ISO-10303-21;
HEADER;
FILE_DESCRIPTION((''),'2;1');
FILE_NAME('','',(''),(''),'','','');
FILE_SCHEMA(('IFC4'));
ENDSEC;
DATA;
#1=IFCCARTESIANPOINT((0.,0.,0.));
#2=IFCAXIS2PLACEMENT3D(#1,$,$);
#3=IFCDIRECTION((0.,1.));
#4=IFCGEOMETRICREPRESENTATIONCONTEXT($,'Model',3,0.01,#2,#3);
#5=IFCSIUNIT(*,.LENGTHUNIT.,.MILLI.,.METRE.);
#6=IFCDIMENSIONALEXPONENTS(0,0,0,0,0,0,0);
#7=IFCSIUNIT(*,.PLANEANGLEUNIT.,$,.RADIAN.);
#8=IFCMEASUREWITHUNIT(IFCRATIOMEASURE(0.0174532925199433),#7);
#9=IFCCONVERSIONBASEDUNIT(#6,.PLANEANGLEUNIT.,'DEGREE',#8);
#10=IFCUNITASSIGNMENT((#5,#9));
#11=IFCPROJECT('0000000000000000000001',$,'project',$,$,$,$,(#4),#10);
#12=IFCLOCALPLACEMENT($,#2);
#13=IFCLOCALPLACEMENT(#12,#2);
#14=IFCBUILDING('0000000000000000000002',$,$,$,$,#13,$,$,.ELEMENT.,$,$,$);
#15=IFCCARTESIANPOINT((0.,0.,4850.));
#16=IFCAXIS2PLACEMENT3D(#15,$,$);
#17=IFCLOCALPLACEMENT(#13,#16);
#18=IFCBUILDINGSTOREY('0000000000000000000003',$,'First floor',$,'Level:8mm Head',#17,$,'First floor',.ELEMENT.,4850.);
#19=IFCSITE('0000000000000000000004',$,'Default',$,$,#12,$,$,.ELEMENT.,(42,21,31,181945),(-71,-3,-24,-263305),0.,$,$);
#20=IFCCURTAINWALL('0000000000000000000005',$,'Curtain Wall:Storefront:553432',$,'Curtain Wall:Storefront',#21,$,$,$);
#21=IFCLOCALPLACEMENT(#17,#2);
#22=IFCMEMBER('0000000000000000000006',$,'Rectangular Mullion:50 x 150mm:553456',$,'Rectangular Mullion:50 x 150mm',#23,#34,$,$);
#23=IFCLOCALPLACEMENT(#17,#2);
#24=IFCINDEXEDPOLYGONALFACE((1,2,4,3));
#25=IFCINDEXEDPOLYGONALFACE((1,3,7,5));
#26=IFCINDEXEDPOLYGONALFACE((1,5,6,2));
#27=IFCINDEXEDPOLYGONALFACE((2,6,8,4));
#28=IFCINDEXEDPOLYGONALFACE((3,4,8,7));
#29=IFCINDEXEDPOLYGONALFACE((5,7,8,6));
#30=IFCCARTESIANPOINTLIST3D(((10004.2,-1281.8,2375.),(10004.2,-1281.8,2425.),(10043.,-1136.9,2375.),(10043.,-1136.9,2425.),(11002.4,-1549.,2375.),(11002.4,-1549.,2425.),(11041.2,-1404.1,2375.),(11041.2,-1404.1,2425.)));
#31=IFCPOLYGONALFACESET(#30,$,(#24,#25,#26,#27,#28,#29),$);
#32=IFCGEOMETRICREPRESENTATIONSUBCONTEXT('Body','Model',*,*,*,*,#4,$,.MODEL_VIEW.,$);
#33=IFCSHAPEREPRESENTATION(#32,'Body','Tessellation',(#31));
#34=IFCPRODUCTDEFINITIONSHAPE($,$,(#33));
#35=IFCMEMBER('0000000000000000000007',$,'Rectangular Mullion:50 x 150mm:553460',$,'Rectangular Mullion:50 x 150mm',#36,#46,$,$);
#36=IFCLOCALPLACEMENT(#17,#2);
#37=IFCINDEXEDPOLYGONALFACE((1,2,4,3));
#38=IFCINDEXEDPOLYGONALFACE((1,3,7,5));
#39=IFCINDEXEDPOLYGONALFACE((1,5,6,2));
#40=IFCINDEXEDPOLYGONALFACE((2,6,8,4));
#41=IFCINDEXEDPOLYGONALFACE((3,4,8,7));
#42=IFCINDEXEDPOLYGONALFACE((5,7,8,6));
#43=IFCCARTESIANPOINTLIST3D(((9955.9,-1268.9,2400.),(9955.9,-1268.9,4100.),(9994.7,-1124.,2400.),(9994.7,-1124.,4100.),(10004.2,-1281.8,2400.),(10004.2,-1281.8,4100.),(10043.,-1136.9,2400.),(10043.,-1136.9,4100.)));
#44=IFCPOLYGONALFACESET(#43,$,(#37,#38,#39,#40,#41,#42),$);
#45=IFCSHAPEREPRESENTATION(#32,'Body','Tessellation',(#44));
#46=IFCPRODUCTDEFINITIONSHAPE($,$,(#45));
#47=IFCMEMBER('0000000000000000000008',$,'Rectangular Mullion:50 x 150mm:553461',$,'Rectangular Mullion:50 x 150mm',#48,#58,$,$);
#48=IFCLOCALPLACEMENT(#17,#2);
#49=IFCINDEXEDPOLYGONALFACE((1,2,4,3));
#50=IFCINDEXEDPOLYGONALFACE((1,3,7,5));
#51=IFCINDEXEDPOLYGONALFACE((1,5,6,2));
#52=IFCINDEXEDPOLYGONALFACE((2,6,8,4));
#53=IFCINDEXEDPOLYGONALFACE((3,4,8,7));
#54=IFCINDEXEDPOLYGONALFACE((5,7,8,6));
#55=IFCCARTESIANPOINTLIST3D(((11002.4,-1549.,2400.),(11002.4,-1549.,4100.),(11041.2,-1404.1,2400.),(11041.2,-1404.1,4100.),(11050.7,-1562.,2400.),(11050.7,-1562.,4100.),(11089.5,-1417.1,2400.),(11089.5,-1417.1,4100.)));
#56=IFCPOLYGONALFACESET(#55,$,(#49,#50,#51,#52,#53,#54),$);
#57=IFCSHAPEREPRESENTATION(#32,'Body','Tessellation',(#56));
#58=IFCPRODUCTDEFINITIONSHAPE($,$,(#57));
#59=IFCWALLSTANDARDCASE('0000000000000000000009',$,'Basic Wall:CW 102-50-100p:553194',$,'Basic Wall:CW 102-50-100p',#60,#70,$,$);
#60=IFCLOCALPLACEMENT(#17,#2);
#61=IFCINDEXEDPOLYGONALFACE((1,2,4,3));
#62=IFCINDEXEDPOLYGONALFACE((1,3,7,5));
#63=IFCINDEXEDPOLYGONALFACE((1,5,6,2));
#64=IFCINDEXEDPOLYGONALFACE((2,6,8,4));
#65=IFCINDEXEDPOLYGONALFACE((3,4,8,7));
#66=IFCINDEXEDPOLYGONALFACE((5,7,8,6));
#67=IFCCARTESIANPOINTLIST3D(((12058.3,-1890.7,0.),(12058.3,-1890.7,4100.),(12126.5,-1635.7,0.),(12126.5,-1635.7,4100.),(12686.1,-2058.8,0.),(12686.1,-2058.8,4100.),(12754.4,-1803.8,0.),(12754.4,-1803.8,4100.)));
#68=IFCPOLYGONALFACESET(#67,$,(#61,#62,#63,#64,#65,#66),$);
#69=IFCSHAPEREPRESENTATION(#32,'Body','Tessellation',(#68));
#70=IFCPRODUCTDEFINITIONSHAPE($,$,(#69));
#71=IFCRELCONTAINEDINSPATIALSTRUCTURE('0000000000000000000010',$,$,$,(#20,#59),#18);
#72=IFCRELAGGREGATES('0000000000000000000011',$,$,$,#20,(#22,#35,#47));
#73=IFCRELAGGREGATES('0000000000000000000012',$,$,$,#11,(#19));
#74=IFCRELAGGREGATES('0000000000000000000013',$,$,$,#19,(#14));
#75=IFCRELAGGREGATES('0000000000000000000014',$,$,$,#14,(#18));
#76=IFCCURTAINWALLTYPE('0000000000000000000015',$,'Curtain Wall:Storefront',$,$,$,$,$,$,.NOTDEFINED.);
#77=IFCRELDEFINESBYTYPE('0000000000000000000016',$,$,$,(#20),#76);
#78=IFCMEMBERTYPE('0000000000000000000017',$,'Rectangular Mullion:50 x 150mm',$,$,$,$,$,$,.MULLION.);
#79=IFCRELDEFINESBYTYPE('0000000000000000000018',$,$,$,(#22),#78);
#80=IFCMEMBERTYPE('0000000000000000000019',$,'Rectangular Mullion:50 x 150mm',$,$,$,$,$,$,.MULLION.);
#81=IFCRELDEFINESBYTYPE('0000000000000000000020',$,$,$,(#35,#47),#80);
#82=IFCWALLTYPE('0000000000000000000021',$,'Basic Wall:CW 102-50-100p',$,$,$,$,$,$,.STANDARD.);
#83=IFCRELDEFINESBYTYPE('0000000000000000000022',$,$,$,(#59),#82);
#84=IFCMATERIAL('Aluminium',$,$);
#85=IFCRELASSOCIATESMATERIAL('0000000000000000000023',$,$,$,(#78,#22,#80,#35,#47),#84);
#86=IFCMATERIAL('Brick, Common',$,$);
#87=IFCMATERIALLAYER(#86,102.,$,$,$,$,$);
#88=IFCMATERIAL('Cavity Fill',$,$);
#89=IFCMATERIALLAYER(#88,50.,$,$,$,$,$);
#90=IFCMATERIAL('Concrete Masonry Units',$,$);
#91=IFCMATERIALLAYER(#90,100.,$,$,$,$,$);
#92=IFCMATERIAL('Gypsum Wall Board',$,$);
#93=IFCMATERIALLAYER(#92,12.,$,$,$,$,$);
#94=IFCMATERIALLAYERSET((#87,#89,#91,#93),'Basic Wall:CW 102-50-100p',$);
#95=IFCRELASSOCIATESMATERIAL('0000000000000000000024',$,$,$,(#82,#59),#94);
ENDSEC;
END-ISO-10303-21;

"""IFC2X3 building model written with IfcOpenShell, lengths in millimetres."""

from ifc_helpers import new_model, entity, si_unit, converted_unit, direction, frame, frame_2d, origin, origin_2d_with_axis, place, context, subcontext, project, spatial, rectangle, extrude, source, transform, mapped, material, layer, layer_set, layer_usage, type_object, type_shapes, element, aggregate, save


model = new_model("IFC2X3")

# Units and contexts
model_context = context("Model", 3, precision=0.01, world=origin(), true_north=direction((0.0, 1.0)))
body_context = subcontext(model_context, "Body", "Model", "MODEL_VIEW")
ifc_project = project(units=[si_unit("LENGTHUNIT", "METRE", prefix="MILLI"), converted_unit("PLANEANGLEUNIT", "DEGREE", entity("IfcRatioMeasure", 0.0174532925199433), si_unit("PLANEANGLEUNIT", "RADIAN"), dimensions=[0, 0, 0, 0, 0, 0, 0])], contexts=[model_context])

# Site, building, storey
site_placement = place(None, origin())
site = spatial("IfcSite", under=ifc_project, at=site_placement, Name="Default", CompositionType="ELEMENT", RefLatitude=(42, 21, 31, 181945), RefLongitude=(-71, -3, -24, -263305), RefElevation=0.0)
building_placement = place(site_placement, origin())
building = spatial("IfcBuilding", under=site, at=building_placement, CompositionType="ELEMENT")
storey_placement = place(building_placement, frame((0.0, 0.0, 4850.0)))
storey = spatial("IfcBuildingStorey", under=building, at=storey_placement, Name="First floor", ObjectType="Level:8mm Head", LongName="First floor", CompositionType="ELEMENT", Elevation=4850.0)

# Curtain wall, members
curtain_wall_type = type_object("IfcCurtainWallType", Name="Curtain Wall:Storefront", PredefinedType="NOTDEFINED")
curtain_wall_placement = place(storey_placement, frame((0.0, 0.0, -4850.0)))
curtain_wall = element("IfcCurtainWall", 1, at=curtain_wall_placement, inside=storey, type_object=curtain_wall_type, Name="Curtain Wall:Storefront:553432", ObjectType="Curtain Wall:Storefront")
ifc_material_1 = material(Name="Aluminium")
member_type_1 = type_object("IfcMemberType", Name="Rectangular Mullion:50 x 150mm", PredefinedType="MULLION", material=ifc_material_1)
shared_shape_1 = source(origin(), body_context, "Body", "SweptSolid", [
    extrude(rectangle(XDim=150.0, YDim=50.0, at=frame_2d((0.0, 0.0), x_axis=(1.0, 0.0))), frame((0.0, 0.0, -1033.3), z_axis=(0.0, 0.0, 1.0), x_axis=(0.0, -1.0, 0.0)), (0.0, 0.0, 1.0), 1033.3),
])
type_shapes(member_type_1, [shared_shape_1])
member_1_placement = place(storey_placement, frame((11021.8, -1476.6, 2400.0), z_axis=(0.965983, -0.258606, 0.0), x_axis=(0.0, 0.0, 1.0)))
member_1 = element("IfcMember", 2, at=member_1_placement, type_object=member_type_1, material=ifc_material_1, Name="Rectangular Mullion:50 x 150mm:553456", ObjectType="Rectangular Mullion:50 x 150mm", context=body_context, shape_type="MappedRepresentation", body=[
    mapped(shared_shape_1, transform((0.0, 0.0, 0.0), scale=1.0)),
])
member_type_2 = type_object("IfcMemberType", Name="Rectangular Mullion:50 x 150mm", PredefinedType="MULLION", material=ifc_material_1)
shared_shape_2 = source(origin(), body_context, "Body", "SweptSolid", [
    extrude(rectangle(XDim=150.0, YDim=50.0, at=origin_2d_with_axis()), frame((0.0, 0.0, -1700.0), z_axis=(0.0, 0.0, 1.0), x_axis=(0.0, -1.0, 0.0)), (0.0, 0.0, 1.0), 1700.0),
])
type_shapes(member_type_2, [shared_shape_2])
member_2_placement = place(storey_placement, frame((9999.4, -1202.9, 2400.0), z_axis=(0.0, 0.0, -1.0), x_axis=(0.965983, -0.258606, 0.0)))
member_2 = element("IfcMember", 3, at=member_2_placement, type_object=member_type_2, material=ifc_material_1, Name="Rectangular Mullion:50 x 150mm:553460", ObjectType="Rectangular Mullion:50 x 150mm", context=body_context, shape_type="MappedRepresentation", body=[
    mapped(shared_shape_2, transform((0.0, 0.0, 0.0), scale=1.0)),
])
member_3_placement = place(storey_placement, frame((11045.9, -1483.1, 2400.0), z_axis=(0.0, 0.0, -1.0), x_axis=(0.965983, -0.258606, 0.0)))
member_3 = element("IfcMember", 4, at=member_3_placement, type_object=member_type_2, material=ifc_material_1, Name="Rectangular Mullion:50 x 150mm:553461", ObjectType="Rectangular Mullion:50 x 150mm", context=body_context, shape_type="MappedRepresentation", body=[
    mapped(shared_shape_2, transform((0.0, 0.0, 0.0), scale=1.0)),
])
aggregate(curtain_wall, [member_1, member_2, member_3])

# Wall
ifc_material_2 = material(Name="Brick, Common")
ifc_layer_1 = layer(ifc_material_2, 102.0)
ifc_material_3 = material(Name="Cavity Fill")
ifc_layer_2 = layer(ifc_material_3, 50.0)
ifc_material_4 = material(Name="Concrete Masonry Units")
ifc_layer_3 = layer(ifc_material_4, 100.0)
ifc_material_5 = material(Name="Gypsum Wall Board")
ifc_layer_4 = layer(ifc_material_5, 12.0)
ifc_layer_set_1 = layer_set([ifc_layer_1, ifc_layer_2, ifc_layer_3, ifc_layer_4], Name="Basic Wall:CW 102-50-100p")
ifc_layer_usage_1 = layer_usage(ifc_layer_set_1, "AXIS2", "NEGATIVE", 132.0)
wall_type_1 = type_object("IfcWallType", Name="Basic Wall:CW 102-50-100p", PredefinedType="STANDARD", material=ifc_layer_set_1)
wall_1_placement = place(storey_placement, frame((12092.4, -1763.2, 0.0), z_axis=(0.0, 0.0, 1.0), x_axis=(0.965983, -0.258606, 0.0)))
element("IfcWallStandardCase", 5, at=wall_1_placement, inside=storey, type_object=wall_type_1, material=ifc_layer_usage_1, Name="Basic Wall:CW 102-50-100p:553194", ObjectType="Basic Wall:CW 102-50-100p", context=body_context, shape_type="SweptSolid", body=[
    extrude(rectangle(XDim=650.0, YDim=264.0, at=frame_2d((325.0, 0.0), x_axis=(-1.0, 0.0))), origin(), (0.0, 0.0, 1.0), 4100.0),
])

save(model, "model.ifc")
